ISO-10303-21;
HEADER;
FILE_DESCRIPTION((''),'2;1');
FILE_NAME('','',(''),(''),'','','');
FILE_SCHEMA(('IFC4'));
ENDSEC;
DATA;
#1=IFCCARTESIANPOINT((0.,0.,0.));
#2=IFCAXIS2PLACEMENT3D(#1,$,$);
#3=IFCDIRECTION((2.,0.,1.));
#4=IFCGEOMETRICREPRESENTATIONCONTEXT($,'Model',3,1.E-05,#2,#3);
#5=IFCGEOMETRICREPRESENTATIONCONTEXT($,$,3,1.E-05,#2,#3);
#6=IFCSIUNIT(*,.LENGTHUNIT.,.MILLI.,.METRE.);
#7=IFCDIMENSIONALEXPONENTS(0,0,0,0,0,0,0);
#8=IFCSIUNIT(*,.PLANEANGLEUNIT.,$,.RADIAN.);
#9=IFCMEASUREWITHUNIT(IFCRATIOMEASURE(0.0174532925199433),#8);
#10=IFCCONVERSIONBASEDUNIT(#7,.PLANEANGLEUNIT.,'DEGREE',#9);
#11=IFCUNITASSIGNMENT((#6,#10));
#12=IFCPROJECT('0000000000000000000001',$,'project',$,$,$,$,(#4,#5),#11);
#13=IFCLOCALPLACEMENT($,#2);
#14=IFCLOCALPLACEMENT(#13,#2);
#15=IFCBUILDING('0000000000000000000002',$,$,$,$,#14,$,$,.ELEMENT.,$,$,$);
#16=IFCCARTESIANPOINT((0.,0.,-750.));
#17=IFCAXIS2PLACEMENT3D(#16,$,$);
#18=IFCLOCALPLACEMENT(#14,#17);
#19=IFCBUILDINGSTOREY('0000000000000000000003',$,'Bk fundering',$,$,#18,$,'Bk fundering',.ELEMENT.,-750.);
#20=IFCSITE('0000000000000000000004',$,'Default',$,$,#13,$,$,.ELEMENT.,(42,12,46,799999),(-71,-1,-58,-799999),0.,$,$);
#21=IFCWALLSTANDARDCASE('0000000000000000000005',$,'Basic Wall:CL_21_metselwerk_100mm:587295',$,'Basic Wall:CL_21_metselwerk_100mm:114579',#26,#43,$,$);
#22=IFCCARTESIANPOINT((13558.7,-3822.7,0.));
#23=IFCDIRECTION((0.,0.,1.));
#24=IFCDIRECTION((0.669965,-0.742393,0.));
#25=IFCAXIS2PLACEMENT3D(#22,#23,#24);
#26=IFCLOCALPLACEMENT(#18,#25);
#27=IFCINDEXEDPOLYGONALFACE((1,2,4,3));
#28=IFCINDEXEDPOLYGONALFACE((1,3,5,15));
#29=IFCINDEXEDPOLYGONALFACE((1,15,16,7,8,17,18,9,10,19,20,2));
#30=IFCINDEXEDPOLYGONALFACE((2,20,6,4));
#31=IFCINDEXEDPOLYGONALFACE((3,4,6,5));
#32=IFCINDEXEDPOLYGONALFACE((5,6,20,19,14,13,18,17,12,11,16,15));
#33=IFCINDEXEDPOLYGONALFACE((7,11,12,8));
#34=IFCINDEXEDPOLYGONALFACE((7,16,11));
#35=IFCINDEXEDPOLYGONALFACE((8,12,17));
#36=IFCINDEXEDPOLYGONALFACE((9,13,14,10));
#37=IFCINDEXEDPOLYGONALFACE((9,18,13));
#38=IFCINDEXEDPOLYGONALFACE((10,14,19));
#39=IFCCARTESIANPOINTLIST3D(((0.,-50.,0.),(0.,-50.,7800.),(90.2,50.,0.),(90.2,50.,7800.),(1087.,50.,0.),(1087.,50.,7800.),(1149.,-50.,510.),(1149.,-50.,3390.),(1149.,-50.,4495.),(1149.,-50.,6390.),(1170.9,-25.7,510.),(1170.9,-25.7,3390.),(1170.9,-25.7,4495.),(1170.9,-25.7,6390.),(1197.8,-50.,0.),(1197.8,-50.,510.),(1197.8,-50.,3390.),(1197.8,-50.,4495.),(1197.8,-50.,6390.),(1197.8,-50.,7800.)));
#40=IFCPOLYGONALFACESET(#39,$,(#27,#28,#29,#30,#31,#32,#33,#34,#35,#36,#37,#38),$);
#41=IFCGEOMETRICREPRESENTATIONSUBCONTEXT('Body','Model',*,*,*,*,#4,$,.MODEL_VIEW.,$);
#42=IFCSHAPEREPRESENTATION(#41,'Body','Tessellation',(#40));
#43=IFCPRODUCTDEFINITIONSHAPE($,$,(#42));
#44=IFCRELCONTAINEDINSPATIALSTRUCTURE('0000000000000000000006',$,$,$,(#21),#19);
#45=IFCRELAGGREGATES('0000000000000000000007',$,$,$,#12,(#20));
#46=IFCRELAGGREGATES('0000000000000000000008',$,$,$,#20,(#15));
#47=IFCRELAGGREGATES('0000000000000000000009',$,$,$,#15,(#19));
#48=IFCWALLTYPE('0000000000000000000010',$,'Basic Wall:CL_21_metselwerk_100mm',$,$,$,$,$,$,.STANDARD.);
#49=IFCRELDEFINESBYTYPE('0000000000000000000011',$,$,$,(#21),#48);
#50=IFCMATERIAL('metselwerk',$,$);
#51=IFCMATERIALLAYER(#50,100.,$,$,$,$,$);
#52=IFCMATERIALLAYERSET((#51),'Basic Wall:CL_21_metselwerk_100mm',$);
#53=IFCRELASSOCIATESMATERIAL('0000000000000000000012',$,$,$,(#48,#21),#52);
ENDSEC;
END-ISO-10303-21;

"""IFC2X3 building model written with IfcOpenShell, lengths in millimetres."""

from ifc_helpers import new_model, entity, si_unit, converted_unit, direction, frame, origin, origin_2d_with_axis, place, context, subcontext, project, spatial, polyline, rectangle, outline, extrude, material, layer, layer_set, layer_usage, type_object, element, save


model = new_model("IFC2X3")

# Units and contexts
model_context = context("Model", 3, precision=1e-05, world=origin(), true_north=direction((2.0, 0.0, 1.0)))
context_of_model = context(None, 3, precision=1e-05, world=origin(), true_north=direction((2.0, 0.0, 1.0)))
body_context = subcontext(model_context, "Body", "Model", "MODEL_VIEW")
ifc_project = project(units=[si_unit("LENGTHUNIT", "METRE", prefix="MILLI"), converted_unit("PLANEANGLEUNIT", "DEGREE", entity("IfcRatioMeasure", 0.0174532925199433), si_unit("PLANEANGLEUNIT", "RADIAN"), dimensions=[0, 0, 0, 0, 0, 0, 0])], contexts=[model_context, context_of_model])

# Site, building, storey
site_placement = place(None, origin())
site = spatial("IfcSite", under=ifc_project, at=site_placement, Name="Default", CompositionType="ELEMENT", RefLatitude=(42, 12, 46, 799999), RefLongitude=(-71, -1, -58, -799999), RefElevation=0.0)
building_placement = place(site_placement, origin())
building = spatial("IfcBuilding", under=site, at=building_placement, CompositionType="ELEMENT")
storey_placement = place(building_placement, frame((0.0, 0.0, -750.0)))
storey = spatial("IfcBuildingStorey", under=building, at=storey_placement, Name="Bk fundering", LongName="Bk fundering", CompositionType="ELEMENT", Elevation=-750.0)

# Shared definitions
ifc_material_1 = material(Name="metselwerk")
ifc_layer_1 = layer(ifc_material_1, 100.0)
ifc_layer_set_1 = layer_set([ifc_layer_1], Name="Basic Wall:CL_21_metselwerk_100mm")
wall_type_1 = type_object("IfcWallType", Name="Basic Wall:CL_21_metselwerk_100mm", PredefinedType="STANDARD", material=ifc_layer_set_1)

# Wall, openings
ifc_layer_usage_1 = layer_usage(ifc_layer_set_1, "AXIS2", "POSITIVE", -50.0)
wall_1_placement = place(storey_placement, frame((13558.7, -3822.7, 0.0), z_axis=(0.0, 0.0, 1.0), x_axis=(0.669965, -0.742393, 0.0)))
wall_1 = element("IfcWallStandardCase", 1, at=wall_1_placement, inside=storey, type_object=wall_type_1, material=ifc_layer_usage_1, Name="Basic Wall:CL_21_metselwerk_100mm:587295", ObjectType="Basic Wall:CL_21_metselwerk_100mm:114579", context=body_context, shape_type="SweptSolid", body=[
    extrude(outline(polyline([(1197.8, -50.0), (1087.0, 50.0), (90.2, 50.0), (0.0, -50.0), (134.7, -50.0), (1048.6, -50.0), (1197.8, -50.0)])), origin(), (0.0, 0.0, 1.0), 7800.0),
])
opening_1_placement = place(wall_1_placement, origin())
element("IfcOpeningElement", 2, at=opening_1_placement, cuts=wall_1, ObjectType="Recess", context=body_context, shape_type="SweptSolid", body=[
    extrude(rectangle(XDim=100.0, YDim=1034.0, at=origin_2d_with_axis()), frame((1521.2, -409.2, 510.0), z_axis=(0.0, 0.0, 1.0), x_axis=(-0.669965, -0.742393, 0.0)), (0.0, 0.0, 1.0), 2880.0),
])
opening_2_placement = place(wall_1_placement, origin())
element("IfcOpeningElement", 3, at=opening_2_placement, cuts=wall_1, ObjectType="Recess", context=body_context, shape_type="SweptSolid", body=[
    extrude(rectangle(XDim=100.0, YDim=1034.0, at=origin_2d_with_axis()), frame((1521.2, -409.2, 4495.0), z_axis=(0.0, 0.0, 1.0), x_axis=(-0.669965, -0.742393, 0.0)), (0.0, 0.0, 1.0), 1895.0),
])

save(model, "model.ifc")
